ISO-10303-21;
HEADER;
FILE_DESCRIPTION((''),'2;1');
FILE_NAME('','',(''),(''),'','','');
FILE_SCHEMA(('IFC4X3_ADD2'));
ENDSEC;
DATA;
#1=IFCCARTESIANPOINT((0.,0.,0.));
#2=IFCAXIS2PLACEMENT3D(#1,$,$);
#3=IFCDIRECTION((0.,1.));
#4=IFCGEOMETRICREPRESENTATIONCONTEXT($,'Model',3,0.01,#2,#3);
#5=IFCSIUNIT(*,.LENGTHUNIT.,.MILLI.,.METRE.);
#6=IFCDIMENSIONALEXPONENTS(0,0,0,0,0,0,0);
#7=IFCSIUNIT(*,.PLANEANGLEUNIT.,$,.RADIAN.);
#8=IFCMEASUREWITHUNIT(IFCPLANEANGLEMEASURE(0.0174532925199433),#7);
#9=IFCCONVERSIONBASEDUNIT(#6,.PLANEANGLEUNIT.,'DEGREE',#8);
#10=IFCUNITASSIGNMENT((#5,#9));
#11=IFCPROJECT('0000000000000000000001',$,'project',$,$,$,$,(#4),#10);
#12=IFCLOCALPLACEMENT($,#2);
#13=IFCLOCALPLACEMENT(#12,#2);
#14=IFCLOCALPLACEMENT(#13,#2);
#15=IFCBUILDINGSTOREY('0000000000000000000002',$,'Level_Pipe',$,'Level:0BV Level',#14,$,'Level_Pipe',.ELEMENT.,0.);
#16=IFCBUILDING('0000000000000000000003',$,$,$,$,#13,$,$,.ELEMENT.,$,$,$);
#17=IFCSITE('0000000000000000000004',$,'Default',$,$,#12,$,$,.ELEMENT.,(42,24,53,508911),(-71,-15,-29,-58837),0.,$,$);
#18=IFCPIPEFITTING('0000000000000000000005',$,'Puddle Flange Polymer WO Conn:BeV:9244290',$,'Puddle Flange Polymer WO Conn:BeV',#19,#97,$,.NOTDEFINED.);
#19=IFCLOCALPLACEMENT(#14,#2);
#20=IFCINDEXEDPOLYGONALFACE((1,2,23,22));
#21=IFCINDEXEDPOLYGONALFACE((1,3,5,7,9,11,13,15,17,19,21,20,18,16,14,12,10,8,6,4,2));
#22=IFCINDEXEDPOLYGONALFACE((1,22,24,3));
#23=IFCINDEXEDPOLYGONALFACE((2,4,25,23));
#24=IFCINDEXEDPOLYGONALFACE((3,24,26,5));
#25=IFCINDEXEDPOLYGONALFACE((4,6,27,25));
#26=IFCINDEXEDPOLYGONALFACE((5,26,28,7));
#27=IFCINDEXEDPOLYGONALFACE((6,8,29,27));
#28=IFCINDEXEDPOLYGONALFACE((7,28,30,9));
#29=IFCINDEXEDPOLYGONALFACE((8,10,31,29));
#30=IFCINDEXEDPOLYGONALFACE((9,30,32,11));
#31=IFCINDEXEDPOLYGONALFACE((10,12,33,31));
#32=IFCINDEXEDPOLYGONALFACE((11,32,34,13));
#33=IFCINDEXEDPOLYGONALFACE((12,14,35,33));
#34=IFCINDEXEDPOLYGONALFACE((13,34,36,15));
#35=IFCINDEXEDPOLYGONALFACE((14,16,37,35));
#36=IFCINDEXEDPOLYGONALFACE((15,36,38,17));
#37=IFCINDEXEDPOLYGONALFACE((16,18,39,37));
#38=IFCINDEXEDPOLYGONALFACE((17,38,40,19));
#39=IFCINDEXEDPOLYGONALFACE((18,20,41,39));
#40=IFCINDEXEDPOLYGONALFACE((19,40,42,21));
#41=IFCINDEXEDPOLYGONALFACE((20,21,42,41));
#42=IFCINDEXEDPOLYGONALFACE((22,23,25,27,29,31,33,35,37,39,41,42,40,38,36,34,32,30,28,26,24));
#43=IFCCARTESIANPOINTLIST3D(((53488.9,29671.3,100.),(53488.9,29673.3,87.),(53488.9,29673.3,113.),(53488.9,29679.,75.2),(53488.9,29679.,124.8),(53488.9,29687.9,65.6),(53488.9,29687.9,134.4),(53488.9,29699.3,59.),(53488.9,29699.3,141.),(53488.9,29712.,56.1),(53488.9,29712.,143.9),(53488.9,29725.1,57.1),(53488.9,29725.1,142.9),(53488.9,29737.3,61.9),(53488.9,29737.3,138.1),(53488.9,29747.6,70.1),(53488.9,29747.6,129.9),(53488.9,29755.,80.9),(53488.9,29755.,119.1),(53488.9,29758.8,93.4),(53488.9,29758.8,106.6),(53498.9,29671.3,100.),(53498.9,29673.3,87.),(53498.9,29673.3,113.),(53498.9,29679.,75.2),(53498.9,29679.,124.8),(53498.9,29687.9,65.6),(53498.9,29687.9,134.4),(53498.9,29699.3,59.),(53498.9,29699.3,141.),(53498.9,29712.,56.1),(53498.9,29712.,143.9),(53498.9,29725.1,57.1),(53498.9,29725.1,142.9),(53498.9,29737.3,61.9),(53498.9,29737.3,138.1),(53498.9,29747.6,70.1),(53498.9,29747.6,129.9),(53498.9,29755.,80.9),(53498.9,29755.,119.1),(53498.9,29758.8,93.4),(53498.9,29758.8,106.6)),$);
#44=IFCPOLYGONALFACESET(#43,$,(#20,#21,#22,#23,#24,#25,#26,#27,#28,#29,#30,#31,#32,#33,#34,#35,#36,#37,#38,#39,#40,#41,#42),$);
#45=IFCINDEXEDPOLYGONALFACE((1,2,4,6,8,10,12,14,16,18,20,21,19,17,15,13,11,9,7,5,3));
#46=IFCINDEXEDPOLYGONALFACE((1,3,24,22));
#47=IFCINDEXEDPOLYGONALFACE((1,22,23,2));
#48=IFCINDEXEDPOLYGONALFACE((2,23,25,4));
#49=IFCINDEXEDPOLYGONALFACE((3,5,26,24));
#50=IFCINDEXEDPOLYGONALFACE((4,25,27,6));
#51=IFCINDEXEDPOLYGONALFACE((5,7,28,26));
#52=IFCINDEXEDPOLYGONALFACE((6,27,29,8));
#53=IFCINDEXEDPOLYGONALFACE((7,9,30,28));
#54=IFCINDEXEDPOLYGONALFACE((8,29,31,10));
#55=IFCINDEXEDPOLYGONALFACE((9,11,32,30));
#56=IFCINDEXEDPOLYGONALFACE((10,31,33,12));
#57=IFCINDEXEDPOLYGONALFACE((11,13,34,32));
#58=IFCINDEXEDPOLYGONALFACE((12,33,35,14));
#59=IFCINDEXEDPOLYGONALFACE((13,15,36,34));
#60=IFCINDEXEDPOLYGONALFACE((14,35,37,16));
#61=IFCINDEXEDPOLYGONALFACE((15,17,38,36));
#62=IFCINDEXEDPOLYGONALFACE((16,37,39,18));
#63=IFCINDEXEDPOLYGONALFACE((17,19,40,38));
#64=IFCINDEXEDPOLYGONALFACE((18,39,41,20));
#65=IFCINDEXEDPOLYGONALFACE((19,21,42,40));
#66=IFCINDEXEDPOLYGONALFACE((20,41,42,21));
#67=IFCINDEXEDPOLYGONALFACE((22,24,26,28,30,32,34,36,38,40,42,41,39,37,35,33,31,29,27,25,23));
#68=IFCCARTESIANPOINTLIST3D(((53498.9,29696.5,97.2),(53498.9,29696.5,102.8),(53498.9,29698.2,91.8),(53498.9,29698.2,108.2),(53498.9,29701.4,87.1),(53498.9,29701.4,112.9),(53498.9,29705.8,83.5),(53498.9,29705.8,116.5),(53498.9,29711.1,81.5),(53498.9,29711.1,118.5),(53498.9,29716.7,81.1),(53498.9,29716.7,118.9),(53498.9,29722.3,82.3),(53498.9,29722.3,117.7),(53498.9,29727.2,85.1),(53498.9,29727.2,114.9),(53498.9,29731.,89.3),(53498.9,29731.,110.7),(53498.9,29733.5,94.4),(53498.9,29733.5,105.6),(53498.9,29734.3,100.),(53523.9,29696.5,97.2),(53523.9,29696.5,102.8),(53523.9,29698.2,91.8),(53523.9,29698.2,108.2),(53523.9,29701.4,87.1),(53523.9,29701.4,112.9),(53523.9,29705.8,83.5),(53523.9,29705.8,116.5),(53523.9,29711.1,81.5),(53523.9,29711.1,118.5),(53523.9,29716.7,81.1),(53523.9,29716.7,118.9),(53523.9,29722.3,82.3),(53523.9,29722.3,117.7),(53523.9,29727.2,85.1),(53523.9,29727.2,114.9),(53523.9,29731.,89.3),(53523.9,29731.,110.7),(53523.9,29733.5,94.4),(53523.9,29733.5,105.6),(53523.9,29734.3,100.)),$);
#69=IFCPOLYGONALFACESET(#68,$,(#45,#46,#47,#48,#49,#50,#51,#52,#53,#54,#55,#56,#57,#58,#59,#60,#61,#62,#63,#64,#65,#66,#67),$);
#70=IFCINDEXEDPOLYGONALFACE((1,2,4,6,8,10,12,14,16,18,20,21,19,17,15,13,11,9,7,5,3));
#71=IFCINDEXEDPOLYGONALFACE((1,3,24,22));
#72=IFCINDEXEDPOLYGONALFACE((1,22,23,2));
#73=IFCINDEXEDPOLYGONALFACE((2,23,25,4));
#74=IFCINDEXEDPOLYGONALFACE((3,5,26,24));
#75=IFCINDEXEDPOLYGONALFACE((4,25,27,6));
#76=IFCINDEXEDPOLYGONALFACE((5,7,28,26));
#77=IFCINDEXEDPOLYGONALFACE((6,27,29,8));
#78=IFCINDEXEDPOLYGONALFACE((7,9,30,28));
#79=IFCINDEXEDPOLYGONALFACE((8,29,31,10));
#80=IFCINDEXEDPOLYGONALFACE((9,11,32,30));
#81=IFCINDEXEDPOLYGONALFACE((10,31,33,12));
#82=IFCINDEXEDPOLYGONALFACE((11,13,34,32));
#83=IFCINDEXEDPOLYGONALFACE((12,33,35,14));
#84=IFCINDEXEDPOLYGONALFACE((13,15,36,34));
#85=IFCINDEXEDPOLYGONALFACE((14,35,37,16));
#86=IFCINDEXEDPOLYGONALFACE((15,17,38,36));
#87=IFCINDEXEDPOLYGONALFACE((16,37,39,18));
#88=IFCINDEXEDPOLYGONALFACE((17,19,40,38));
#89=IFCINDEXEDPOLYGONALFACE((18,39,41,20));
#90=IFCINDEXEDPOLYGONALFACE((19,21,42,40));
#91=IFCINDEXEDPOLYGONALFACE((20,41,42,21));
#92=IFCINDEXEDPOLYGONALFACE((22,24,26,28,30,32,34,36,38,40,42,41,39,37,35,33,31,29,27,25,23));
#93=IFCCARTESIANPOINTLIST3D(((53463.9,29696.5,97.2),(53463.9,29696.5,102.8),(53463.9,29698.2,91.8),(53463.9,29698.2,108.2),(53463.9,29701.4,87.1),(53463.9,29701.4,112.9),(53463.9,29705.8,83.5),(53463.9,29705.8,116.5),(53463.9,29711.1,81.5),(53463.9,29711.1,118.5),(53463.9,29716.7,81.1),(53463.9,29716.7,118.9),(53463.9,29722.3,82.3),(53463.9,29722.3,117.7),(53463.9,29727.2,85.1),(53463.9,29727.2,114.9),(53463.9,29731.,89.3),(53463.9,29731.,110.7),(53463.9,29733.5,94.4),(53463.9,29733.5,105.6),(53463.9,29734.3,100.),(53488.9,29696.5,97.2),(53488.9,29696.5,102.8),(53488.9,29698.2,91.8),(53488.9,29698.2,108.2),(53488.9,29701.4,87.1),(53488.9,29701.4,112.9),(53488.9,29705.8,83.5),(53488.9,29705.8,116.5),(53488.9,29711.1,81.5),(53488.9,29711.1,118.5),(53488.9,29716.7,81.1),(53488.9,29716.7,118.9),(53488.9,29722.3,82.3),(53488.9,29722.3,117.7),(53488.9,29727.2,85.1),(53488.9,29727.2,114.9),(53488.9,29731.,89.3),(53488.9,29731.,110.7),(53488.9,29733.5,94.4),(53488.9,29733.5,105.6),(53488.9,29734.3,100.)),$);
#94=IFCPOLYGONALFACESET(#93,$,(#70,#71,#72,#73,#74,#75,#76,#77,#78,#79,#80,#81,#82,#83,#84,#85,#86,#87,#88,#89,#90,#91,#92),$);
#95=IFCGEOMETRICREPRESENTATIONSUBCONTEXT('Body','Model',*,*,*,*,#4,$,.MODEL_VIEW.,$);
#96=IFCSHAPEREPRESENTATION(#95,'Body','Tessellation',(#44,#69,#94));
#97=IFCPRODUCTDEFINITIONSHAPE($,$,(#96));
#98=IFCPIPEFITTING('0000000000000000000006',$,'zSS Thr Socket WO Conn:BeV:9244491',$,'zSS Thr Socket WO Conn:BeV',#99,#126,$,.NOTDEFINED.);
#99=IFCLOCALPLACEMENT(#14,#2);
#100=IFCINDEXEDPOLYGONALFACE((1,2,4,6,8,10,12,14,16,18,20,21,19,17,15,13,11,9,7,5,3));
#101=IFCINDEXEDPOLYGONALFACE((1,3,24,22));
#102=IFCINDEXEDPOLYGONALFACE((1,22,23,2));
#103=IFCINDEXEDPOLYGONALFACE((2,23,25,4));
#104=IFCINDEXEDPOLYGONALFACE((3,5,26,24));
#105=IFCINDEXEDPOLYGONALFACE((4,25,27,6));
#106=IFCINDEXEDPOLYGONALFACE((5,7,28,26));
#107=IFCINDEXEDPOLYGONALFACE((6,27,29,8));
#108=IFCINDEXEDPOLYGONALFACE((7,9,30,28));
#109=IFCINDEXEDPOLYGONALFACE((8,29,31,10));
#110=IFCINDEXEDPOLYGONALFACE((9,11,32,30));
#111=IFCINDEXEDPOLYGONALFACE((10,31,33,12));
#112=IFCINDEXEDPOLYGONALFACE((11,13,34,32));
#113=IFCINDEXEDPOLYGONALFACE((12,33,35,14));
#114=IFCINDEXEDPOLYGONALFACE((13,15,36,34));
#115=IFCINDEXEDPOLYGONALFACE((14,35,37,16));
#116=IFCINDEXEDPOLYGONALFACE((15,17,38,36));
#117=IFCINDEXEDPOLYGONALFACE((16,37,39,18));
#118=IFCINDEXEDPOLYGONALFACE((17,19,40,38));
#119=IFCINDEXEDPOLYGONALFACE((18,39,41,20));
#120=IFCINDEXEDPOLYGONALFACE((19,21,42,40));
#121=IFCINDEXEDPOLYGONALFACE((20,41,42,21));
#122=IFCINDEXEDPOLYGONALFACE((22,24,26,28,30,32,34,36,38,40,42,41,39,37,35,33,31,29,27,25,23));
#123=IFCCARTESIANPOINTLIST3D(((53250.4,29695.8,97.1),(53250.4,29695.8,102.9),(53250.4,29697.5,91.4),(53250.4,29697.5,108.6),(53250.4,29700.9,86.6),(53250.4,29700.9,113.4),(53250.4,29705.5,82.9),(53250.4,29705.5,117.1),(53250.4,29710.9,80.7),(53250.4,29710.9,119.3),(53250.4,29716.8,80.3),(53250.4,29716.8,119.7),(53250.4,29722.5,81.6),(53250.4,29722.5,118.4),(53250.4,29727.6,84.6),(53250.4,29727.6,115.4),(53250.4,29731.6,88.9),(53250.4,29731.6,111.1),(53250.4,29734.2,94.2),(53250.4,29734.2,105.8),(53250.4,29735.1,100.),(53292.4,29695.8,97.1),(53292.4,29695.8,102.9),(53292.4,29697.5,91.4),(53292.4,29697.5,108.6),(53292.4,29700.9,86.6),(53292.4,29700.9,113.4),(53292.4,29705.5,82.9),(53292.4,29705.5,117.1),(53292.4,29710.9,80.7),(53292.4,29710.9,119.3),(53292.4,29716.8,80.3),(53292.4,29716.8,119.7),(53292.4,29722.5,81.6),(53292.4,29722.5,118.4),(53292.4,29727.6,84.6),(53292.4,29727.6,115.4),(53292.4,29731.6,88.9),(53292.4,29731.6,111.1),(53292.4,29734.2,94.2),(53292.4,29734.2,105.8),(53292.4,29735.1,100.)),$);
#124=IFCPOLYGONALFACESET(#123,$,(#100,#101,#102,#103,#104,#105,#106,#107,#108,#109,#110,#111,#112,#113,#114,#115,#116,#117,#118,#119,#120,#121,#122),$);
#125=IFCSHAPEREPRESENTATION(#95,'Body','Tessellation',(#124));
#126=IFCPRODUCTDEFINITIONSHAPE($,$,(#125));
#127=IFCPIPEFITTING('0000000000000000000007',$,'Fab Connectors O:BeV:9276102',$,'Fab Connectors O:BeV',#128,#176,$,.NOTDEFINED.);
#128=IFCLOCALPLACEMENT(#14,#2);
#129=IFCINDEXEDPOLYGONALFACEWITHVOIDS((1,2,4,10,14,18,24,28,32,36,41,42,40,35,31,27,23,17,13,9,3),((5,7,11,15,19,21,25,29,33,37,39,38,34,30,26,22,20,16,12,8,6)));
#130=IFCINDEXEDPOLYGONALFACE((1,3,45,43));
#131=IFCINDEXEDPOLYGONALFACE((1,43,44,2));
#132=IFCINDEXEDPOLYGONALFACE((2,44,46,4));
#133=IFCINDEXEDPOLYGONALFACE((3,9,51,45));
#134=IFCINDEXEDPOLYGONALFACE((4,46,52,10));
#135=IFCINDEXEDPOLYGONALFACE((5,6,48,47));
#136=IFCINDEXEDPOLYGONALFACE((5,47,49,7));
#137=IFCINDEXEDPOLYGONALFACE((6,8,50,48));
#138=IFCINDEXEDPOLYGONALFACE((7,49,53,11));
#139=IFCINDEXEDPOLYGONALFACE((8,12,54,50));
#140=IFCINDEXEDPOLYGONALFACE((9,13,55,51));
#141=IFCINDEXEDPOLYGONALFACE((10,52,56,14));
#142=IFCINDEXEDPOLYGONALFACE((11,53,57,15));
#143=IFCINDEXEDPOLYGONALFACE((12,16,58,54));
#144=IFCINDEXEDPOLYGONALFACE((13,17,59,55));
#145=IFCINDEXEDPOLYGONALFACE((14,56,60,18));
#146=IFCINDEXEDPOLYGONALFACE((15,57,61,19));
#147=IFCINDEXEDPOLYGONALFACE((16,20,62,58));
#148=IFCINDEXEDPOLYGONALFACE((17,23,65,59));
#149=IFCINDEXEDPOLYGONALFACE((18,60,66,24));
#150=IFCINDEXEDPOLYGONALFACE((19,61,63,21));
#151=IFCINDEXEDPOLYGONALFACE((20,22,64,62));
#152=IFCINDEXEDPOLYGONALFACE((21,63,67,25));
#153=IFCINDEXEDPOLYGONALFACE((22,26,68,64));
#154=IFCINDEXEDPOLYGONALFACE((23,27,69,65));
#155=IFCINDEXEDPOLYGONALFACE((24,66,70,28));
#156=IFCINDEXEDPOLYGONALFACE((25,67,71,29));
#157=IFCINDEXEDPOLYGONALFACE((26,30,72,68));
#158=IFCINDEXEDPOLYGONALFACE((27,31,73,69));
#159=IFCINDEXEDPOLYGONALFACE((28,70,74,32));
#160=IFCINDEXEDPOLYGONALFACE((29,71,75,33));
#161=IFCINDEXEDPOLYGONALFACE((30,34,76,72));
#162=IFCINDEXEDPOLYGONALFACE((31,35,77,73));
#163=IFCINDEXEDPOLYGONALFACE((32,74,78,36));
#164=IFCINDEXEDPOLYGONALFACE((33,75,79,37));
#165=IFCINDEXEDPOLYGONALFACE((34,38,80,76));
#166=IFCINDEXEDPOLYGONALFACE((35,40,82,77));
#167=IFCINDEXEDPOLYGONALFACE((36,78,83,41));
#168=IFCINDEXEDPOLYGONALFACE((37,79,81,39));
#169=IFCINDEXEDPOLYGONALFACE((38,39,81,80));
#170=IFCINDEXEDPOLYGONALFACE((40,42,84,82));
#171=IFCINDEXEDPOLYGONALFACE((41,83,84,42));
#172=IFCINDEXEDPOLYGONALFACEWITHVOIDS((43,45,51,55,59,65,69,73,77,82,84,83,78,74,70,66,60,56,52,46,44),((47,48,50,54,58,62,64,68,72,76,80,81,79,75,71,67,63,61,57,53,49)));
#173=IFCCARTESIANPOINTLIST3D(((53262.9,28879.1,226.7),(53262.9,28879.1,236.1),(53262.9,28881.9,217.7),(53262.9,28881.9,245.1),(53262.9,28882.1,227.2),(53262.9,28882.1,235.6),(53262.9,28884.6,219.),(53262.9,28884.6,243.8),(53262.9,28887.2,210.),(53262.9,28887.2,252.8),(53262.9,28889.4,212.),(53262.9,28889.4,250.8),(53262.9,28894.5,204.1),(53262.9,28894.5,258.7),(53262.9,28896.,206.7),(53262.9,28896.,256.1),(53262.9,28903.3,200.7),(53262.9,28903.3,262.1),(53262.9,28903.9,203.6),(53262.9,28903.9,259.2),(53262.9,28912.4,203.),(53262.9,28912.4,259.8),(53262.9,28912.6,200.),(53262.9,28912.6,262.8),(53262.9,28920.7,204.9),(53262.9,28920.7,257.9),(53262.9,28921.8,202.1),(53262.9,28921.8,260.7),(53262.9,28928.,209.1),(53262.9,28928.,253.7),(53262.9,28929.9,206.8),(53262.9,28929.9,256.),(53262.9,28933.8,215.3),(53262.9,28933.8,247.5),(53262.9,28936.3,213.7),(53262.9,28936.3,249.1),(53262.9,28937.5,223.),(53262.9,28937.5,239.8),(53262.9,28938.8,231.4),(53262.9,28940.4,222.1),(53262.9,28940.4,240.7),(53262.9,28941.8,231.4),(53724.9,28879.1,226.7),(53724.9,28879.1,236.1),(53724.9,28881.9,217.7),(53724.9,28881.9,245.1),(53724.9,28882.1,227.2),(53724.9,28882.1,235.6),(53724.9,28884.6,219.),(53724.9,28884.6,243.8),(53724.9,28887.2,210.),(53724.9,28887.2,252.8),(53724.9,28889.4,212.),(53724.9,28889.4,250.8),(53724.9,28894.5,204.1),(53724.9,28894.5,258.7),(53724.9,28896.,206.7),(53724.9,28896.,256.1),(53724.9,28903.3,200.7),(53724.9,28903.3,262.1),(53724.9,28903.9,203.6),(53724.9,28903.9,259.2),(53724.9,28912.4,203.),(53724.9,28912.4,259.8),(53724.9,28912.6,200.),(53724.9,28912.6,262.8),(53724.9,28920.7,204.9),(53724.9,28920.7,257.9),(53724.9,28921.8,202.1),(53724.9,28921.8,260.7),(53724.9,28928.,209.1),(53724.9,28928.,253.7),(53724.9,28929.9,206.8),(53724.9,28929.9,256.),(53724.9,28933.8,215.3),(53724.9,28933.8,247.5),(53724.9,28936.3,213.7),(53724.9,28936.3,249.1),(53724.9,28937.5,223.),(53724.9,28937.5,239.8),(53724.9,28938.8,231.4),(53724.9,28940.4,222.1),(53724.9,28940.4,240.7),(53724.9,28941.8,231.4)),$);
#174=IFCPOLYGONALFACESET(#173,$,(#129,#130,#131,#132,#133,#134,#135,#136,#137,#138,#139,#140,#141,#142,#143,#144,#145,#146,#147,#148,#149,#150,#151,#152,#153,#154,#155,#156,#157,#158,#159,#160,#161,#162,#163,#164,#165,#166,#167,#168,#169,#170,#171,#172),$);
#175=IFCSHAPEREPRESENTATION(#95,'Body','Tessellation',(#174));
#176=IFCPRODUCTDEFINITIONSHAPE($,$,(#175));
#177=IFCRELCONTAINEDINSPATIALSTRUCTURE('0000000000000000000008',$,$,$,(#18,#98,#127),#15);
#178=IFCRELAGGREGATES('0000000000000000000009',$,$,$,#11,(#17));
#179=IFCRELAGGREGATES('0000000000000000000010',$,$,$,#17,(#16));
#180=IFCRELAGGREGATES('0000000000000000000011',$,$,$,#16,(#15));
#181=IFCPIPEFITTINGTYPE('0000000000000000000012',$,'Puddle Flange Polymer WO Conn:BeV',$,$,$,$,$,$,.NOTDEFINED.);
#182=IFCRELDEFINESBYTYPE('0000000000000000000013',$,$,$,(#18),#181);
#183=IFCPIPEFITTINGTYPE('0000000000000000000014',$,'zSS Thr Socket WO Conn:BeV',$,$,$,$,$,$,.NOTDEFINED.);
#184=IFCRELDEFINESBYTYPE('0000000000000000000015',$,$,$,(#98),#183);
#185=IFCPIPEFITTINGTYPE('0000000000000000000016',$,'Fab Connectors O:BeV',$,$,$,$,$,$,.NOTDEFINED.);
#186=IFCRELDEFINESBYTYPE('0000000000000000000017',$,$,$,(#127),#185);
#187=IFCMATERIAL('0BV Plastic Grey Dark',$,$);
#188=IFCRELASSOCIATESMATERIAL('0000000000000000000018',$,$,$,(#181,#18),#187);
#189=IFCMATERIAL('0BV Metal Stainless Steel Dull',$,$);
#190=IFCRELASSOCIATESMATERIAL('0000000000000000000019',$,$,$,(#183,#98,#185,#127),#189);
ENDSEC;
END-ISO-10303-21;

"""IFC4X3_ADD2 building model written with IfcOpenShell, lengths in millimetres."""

from ifc_helpers import new_model, entity, si_unit, converted_unit, direction, frame, frame_2d, origin, place, context, subcontext, project, spatial, circle, hollow_circle, extrude, source, transform, mapped, material, type_object, type_shapes, element, save


model = new_model("IFC4X3_ADD2")

# Units and contexts
model_context = context("Model", 3, precision=0.01, world=origin(), true_north=direction((0.0, 1.0)))
body_context = subcontext(model_context, "Body", "Model", "MODEL_VIEW")
ifc_project = project(units=[si_unit("LENGTHUNIT", "METRE", prefix="MILLI"), converted_unit("PLANEANGLEUNIT", "DEGREE", entity("IfcPlaneAngleMeasure", 0.0174532925199433), si_unit("PLANEANGLEUNIT", "RADIAN"), dimensions=[0, 0, 0, 0, 0, 0, 0])], contexts=[model_context])

# Site, building, storey
site_placement = place(None, origin())
site = spatial("IfcSite", under=ifc_project, at=site_placement, Name="Default", CompositionType="ELEMENT", RefLatitude=(42, 24, 53, 508911), RefLongitude=(-71, -15, -29, -58837), RefElevation=0.0)
building_placement = place(site_placement, origin())
building = spatial("IfcBuilding", under=site, at=building_placement, CompositionType="ELEMENT")
storey_placement = place(building_placement, origin())
storey = spatial("IfcBuildingStorey", under=building, at=storey_placement, Name="Level_Pipe", ObjectType="Level:0BV Level", LongName="Level_Pipe", CompositionType="ELEMENT", Elevation=0.0)

# Shared definitions
ifc_material_1 = material(Name="0BV Metal Stainless Steel Dull")

# Pipe fittings
ifc_material_2 = material(Name="0BV Plastic Grey Dark")
pipe_fitting_type_1 = type_object("IfcPipeFittingType", Name="Puddle Flange Polymer WO Conn:BeV", PredefinedType="NOTDEFINED", material=ifc_material_2)
shared_shape_1 = source(origin(), body_context, "Body", "SweptSolid", [
    extrude(circle(Radius=44.0, at=frame_2d((0.0, 0.0), x_axis=(1.0, 0.0))), frame((-5.0, 0.0, 0.0), z_axis=(1.0, 0.0, 0.0), x_axis=(0.0, -1.0, 0.0)), (0.0, 0.0, 1.0), 10.0),
    extrude(circle(Radius=19.0, at=frame_2d((0.0, 0.0), x_axis=(1.0, 0.0))), frame((5.0, 0.0, 0.0), z_axis=(1.0, 0.0, 0.0), x_axis=(0.0, 1.0, 0.0)), (0.0, 0.0, 1.0), 25.0),
    extrude(circle(Radius=19.0, at=frame_2d((0.0, 0.0), x_axis=(1.0, 0.0))), frame((-30.0, 0.0, 0.0), z_axis=(1.0, 0.0, 0.0), x_axis=(0.0, 1.0, 0.0)), (0.0, 0.0, 1.0), 25.0),
])
type_shapes(pipe_fitting_type_1, [shared_shape_1])
pipe_fitting_1_placement = place(storey_placement, frame((53493.9, 29715.3, 100.0)))
element("IfcPipeFitting", 1, at=pipe_fitting_1_placement, inside=storey, type_object=pipe_fitting_type_1, material=ifc_material_2, Name="Puddle Flange Polymer WO Conn:BeV:9244290", ObjectType="Puddle Flange Polymer WO Conn:BeV", PredefinedType="NOTDEFINED", context=body_context, shape_type="MappedRepresentation", body=[
    mapped(shared_shape_1, transform((0.0, 0.0, 0.0), scale=1.0)),
])
pipe_fitting_type_2 = type_object("IfcPipeFittingType", Name="zSS Thr Socket WO Conn:BeV", PredefinedType="NOTDEFINED", material=ifc_material_1)
shared_shape_2 = source(origin(), body_context, "Body", "SweptSolid", [
    extrude(circle(Radius=19.8, at=frame_2d((0.0, 0.0), x_axis=(1.0, 0.0))), frame((-21.0, 0.0, 0.0), z_axis=(1.0, 0.0, 0.0), x_axis=(0.0, 1.0, 0.0)), (0.0, 0.0, 1.0), 42.0),
])
type_shapes(pipe_fitting_type_2, [shared_shape_2])
pipe_fitting_2_placement = place(storey_placement, frame((53271.4, 29715.3, 100.0)))
element("IfcPipeFitting", 2, at=pipe_fitting_2_placement, inside=storey, type_object=pipe_fitting_type_2, material=ifc_material_1, Name="zSS Thr Socket WO Conn:BeV:9244491", ObjectType="zSS Thr Socket WO Conn:BeV", PredefinedType="NOTDEFINED", context=body_context, shape_type="MappedRepresentation", body=[
    mapped(shared_shape_2, transform((0.0, 0.0, 0.0), scale=1.0)),
])
pipe_fitting_type_3 = type_object("IfcPipeFittingType", Name="Fab Connectors O:BeV", PredefinedType="NOTDEFINED", material=ifc_material_1)
shared_shape_3 = source(origin(), body_context, "Body", "SweptSolid", [
    extrude(hollow_circle(Radius=31.5, WallThickness=3.0, at=frame_2d((0.0, 0.0), x_axis=(1.0, 0.0))), frame((0.0, 33.1, 33.1), z_axis=(1.0, 0.0, 0.0), x_axis=(0.0, 1.0, 0.0)), (0.0, 0.0, 1.0), 462.0),
])
type_shapes(pipe_fitting_type_3, [shared_shape_3])
pipe_fitting_3_placement = place(storey_placement, frame((53262.9, 28877.2, 198.3)))
element("IfcPipeFitting", 3, at=pipe_fitting_3_placement, inside=storey, type_object=pipe_fitting_type_3, material=ifc_material_1, Name="Fab Connectors O:BeV:9276102", ObjectType="Fab Connectors O:BeV", PredefinedType="NOTDEFINED", context=body_context, shape_type="MappedRepresentation", body=[
    mapped(shared_shape_3, transform((0.0, 0.0, 0.0), scale=1.0)),
])

save(model, "model.ifc")
